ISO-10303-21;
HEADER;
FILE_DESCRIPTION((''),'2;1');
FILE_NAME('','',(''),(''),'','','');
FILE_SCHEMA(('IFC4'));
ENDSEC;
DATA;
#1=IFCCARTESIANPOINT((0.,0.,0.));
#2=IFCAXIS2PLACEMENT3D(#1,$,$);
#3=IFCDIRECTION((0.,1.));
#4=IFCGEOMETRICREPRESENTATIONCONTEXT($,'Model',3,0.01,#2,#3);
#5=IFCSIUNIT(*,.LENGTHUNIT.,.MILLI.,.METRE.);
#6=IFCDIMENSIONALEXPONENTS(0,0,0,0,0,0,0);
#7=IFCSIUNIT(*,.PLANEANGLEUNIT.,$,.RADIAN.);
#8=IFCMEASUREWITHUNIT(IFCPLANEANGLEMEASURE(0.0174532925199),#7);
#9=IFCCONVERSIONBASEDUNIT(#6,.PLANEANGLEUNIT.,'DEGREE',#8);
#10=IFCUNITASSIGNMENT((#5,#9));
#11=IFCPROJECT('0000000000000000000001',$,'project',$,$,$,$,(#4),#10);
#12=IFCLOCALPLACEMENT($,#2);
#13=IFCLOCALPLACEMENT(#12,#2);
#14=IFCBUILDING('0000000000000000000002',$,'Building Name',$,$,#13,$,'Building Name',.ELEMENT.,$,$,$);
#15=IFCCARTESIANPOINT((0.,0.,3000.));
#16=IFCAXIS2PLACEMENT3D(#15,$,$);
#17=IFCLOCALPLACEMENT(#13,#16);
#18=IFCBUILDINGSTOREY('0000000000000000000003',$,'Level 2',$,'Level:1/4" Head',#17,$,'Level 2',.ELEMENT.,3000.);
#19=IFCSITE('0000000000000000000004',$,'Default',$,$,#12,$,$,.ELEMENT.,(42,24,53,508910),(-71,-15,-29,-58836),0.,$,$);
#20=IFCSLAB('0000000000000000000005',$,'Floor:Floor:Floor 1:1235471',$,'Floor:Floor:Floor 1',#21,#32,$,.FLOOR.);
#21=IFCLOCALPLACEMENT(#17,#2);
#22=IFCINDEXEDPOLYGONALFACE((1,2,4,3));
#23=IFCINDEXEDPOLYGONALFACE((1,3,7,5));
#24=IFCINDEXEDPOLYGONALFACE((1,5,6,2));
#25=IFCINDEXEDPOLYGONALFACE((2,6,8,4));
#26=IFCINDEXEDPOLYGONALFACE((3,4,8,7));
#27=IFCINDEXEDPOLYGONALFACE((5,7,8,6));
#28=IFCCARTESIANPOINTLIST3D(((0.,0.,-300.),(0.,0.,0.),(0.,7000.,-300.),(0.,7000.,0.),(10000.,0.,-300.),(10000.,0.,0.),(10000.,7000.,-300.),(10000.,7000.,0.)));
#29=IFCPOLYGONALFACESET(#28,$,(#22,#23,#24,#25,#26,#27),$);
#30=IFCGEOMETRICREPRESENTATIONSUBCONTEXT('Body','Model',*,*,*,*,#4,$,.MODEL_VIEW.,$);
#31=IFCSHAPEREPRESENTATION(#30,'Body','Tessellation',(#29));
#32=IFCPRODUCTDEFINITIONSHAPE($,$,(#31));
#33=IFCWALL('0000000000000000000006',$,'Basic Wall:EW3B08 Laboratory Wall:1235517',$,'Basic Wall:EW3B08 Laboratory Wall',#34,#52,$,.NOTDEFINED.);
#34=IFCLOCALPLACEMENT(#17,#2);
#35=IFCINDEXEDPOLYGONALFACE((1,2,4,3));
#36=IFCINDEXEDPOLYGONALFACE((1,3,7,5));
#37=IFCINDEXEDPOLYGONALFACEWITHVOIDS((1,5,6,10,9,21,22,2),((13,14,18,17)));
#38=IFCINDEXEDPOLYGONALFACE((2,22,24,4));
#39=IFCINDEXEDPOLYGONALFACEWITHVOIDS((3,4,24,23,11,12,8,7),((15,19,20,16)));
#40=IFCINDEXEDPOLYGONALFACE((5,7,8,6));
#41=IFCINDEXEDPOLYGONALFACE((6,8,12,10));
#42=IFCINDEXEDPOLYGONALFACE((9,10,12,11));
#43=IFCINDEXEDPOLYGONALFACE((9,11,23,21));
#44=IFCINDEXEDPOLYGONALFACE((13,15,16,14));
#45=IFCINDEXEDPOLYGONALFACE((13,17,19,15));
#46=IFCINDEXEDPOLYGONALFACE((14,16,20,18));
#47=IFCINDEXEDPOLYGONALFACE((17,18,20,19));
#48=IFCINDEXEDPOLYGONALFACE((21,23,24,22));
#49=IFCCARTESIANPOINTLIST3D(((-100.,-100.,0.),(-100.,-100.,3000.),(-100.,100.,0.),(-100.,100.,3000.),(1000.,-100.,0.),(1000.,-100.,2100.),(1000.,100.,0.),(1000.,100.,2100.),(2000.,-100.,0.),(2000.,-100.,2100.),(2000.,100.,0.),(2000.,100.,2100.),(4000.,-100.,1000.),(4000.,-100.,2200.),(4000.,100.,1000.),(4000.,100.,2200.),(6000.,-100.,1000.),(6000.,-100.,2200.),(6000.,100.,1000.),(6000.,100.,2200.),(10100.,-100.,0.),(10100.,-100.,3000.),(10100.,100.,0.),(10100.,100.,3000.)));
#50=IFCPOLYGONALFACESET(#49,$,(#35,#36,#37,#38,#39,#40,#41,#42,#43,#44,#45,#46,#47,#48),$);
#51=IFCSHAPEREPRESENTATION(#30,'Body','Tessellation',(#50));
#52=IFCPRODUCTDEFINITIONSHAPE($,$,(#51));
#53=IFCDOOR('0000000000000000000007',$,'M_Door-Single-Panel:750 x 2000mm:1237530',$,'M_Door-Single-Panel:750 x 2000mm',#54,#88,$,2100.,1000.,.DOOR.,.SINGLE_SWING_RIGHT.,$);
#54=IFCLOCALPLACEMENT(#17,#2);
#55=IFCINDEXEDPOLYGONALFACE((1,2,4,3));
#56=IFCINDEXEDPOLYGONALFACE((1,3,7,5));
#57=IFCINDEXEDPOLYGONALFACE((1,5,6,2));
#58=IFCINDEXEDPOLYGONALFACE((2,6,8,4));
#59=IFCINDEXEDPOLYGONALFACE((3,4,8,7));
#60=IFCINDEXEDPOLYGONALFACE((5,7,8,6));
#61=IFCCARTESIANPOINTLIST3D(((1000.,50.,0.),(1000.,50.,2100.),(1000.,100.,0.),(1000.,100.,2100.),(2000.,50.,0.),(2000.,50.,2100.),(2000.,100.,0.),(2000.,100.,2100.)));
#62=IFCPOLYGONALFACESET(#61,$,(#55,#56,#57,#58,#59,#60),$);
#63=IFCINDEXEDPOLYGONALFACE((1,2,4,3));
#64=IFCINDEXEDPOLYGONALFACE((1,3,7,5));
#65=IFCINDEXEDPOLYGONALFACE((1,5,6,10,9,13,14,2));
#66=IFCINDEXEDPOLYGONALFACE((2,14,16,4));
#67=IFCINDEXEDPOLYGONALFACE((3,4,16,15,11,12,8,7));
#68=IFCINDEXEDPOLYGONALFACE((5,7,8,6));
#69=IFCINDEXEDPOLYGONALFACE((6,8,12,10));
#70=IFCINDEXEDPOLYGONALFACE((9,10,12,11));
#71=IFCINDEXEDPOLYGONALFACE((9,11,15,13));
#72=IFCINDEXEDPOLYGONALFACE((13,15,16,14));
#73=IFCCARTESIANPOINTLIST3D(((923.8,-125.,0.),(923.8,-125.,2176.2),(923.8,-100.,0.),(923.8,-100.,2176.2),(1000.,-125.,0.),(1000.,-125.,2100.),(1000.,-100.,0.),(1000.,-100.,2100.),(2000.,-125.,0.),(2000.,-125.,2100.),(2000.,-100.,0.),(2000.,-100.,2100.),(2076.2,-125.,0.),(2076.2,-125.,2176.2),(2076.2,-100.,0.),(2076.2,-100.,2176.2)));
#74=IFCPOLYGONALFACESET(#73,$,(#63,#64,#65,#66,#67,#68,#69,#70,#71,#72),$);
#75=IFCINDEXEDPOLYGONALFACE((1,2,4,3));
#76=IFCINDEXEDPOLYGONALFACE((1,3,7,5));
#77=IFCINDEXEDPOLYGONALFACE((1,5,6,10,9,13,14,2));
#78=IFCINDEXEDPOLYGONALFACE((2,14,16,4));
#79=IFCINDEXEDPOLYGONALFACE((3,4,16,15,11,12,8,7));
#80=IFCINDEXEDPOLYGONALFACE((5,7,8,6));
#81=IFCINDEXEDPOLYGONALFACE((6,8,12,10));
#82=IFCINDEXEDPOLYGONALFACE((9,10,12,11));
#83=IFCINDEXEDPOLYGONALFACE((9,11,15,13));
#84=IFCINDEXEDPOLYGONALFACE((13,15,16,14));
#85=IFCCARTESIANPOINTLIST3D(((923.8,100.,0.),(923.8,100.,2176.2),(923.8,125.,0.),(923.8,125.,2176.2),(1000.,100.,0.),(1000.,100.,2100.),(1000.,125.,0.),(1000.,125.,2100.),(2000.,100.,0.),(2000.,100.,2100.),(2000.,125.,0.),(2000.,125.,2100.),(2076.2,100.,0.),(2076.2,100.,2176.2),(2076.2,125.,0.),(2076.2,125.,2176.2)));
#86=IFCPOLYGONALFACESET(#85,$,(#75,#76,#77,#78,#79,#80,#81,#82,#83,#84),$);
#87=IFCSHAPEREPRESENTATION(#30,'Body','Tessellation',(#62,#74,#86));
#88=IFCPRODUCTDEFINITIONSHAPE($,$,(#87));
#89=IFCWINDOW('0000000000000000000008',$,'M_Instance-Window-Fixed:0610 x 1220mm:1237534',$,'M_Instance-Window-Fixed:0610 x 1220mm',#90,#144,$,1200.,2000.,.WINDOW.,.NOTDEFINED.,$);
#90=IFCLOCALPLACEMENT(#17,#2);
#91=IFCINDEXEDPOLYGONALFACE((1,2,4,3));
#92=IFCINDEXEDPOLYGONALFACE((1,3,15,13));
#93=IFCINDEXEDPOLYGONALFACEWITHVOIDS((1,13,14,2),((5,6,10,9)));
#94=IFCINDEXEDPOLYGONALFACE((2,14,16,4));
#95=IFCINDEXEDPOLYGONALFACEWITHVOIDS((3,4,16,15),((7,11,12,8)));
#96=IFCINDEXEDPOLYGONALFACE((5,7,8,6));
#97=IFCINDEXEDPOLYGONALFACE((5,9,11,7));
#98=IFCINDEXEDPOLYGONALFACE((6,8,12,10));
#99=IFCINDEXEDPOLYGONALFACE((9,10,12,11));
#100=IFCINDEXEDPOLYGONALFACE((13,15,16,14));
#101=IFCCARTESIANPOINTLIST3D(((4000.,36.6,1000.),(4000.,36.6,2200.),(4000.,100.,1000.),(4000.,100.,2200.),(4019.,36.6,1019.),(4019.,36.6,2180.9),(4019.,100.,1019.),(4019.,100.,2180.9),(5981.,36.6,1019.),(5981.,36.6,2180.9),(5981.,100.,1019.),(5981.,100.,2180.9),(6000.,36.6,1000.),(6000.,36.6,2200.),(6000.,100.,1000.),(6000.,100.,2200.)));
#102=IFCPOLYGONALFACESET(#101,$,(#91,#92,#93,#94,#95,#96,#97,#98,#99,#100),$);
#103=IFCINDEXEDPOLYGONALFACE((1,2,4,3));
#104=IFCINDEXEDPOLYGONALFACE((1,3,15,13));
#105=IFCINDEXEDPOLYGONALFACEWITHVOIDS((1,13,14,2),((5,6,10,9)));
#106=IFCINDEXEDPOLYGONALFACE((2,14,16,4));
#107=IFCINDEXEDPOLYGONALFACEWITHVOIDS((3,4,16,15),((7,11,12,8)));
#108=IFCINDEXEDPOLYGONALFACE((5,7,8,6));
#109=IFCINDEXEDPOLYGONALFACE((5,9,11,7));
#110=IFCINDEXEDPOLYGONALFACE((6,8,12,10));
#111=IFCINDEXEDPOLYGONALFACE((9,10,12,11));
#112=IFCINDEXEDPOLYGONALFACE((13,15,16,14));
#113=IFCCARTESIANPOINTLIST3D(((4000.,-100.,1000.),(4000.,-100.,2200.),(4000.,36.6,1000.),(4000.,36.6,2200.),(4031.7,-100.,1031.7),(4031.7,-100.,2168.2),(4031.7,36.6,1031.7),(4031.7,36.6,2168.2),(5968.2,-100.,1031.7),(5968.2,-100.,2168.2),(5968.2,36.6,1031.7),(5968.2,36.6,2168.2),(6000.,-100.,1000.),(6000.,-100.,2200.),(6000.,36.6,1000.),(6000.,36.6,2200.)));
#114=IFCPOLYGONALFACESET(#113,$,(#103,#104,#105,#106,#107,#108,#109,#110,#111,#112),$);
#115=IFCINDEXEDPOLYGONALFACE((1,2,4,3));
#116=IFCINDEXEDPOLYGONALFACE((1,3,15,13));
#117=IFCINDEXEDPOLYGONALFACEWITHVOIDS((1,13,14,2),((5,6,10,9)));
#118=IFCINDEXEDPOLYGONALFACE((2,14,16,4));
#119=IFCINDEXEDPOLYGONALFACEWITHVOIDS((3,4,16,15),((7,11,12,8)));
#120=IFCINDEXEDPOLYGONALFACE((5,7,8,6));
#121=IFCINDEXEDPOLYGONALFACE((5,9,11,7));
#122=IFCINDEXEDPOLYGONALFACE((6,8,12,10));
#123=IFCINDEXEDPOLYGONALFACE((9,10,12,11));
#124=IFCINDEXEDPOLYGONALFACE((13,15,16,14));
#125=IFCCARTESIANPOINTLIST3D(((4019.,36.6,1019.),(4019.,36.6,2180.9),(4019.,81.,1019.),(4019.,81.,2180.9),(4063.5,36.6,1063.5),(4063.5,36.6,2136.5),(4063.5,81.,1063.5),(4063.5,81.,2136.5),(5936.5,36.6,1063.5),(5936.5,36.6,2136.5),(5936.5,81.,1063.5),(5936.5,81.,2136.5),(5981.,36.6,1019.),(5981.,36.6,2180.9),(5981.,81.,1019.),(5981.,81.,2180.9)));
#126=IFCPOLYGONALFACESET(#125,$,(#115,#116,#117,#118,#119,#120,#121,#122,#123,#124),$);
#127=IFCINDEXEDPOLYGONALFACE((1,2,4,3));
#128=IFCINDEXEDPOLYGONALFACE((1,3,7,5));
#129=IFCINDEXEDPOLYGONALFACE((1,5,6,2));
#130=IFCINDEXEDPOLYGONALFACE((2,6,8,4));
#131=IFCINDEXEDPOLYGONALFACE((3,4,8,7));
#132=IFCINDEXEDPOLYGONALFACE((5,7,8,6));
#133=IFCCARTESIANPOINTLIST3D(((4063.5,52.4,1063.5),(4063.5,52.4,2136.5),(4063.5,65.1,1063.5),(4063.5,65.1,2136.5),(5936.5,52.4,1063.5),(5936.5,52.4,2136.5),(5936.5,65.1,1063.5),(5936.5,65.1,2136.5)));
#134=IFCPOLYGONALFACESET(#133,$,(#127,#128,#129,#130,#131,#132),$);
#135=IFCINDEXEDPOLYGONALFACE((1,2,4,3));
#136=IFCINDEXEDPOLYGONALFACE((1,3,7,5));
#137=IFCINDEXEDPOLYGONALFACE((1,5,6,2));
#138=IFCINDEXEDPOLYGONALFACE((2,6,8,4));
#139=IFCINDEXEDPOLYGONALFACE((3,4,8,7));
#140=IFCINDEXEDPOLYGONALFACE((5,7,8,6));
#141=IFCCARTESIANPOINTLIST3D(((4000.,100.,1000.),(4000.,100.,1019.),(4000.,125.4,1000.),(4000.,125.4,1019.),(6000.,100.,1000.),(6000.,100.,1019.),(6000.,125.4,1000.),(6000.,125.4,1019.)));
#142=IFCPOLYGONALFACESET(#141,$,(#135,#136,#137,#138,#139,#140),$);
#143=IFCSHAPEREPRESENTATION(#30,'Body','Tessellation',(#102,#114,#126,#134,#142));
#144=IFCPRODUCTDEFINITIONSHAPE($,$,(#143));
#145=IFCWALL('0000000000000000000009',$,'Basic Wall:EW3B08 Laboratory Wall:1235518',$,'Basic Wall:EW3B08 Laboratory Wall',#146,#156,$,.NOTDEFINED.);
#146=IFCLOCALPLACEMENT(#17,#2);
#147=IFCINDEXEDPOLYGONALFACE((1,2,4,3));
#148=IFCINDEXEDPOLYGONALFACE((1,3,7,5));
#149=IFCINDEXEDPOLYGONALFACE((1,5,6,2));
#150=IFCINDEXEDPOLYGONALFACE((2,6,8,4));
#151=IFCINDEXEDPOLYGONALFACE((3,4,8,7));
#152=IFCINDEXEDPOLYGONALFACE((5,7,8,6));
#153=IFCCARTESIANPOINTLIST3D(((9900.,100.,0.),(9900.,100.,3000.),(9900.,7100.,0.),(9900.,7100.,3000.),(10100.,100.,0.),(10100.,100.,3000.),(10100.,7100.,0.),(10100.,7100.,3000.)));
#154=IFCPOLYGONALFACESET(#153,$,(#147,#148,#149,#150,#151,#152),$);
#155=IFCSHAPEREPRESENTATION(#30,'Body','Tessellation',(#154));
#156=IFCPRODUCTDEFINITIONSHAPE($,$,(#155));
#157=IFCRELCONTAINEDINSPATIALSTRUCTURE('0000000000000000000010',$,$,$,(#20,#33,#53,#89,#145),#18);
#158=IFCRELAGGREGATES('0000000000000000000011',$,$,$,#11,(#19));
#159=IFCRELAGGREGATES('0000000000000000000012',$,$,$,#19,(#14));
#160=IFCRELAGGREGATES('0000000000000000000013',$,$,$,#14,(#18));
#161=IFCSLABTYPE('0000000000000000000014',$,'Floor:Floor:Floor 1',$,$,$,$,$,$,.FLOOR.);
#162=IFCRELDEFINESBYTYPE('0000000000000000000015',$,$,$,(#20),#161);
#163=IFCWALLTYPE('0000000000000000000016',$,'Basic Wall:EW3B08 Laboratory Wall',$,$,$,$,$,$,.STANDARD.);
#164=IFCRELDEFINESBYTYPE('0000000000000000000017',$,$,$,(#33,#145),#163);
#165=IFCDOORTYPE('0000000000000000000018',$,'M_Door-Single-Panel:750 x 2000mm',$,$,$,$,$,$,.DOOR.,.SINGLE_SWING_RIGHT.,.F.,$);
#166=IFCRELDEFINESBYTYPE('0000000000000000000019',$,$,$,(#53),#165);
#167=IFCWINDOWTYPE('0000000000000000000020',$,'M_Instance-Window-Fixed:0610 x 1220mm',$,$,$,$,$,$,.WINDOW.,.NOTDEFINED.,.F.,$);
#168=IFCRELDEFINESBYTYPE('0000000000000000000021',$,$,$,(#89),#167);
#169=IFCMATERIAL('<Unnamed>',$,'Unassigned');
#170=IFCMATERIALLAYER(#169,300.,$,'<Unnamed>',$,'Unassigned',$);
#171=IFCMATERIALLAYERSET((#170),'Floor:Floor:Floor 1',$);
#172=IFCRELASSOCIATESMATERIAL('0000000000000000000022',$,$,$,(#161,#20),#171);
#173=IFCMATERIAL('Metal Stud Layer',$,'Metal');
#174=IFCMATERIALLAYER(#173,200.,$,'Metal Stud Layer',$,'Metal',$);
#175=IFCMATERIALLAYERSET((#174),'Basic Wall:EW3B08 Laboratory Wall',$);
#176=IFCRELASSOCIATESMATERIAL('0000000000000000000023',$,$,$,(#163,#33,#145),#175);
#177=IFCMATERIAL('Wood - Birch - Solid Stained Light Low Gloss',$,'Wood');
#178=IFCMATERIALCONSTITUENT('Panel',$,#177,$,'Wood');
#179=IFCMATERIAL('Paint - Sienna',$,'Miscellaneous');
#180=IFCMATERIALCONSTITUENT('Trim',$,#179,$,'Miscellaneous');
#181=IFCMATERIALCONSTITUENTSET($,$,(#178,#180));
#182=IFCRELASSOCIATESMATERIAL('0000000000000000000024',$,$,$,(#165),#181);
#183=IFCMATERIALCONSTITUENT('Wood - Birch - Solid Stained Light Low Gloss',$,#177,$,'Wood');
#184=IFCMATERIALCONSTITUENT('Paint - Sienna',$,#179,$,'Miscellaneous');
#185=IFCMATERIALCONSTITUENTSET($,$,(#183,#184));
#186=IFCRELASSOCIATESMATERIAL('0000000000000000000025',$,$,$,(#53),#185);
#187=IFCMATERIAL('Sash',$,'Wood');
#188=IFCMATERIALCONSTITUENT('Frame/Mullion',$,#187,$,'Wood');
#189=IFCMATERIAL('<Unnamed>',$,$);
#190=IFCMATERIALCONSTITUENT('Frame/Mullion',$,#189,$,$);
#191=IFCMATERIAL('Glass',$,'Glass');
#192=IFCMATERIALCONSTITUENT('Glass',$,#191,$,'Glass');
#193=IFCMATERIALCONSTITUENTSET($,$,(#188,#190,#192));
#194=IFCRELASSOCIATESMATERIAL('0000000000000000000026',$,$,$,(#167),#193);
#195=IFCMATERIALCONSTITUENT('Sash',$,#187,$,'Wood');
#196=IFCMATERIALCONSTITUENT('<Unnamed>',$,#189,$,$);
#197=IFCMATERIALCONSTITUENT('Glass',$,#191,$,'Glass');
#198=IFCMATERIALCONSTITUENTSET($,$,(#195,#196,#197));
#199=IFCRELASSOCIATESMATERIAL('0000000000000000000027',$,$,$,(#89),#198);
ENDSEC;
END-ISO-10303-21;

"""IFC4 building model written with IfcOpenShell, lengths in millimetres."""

from ifc_helpers import new_model, entity, si_unit, converted_unit, direction, frame, frame_2d, origin, origin_2d_with_axis, place, context, subcontext, project, spatial, polyline, rectangle, outline, extrude, source, transform, mapped, material, layer, layer_set, layer_usage, constituent, constituent_set, type_object, type_shapes, element, fill, save


model = new_model("IFC4")

# Units and contexts
model_context = context("Model", 3, precision=0.01, world=origin(), true_north=direction((0.0, 1.0)))
body_context = subcontext(model_context, "Body", "Model", "MODEL_VIEW")
ifc_project = project(units=[si_unit("LENGTHUNIT", "METRE", prefix="MILLI"), converted_unit("PLANEANGLEUNIT", "DEGREE", entity("IfcPlaneAngleMeasure", 0.0174532925199), si_unit("PLANEANGLEUNIT", "RADIAN"), dimensions=[0, 0, 0, 0, 0, 0, 0])], contexts=[model_context])

# Site, building, storey
site_placement = place(None, origin())
site = spatial("IfcSite", under=ifc_project, at=site_placement, Name="Default", CompositionType="ELEMENT", RefLatitude=(42, 24, 53, 508910), RefLongitude=(-71, -15, -29, -58836), RefElevation=0.0)
building_placement = place(site_placement, origin())
building = spatial("IfcBuilding", under=site, at=building_placement, Name="Building Name", LongName="Building Name", CompositionType="ELEMENT")
storey_placement = place(building_placement, frame((0.0, 0.0, 3000.0)))
storey = spatial("IfcBuildingStorey", under=building, at=storey_placement, Name="Level 2", ObjectType="Level:1/4\" Head", LongName="Level 2", CompositionType="ELEMENT", Elevation=3000.0)

# Slab
ifc_material_1 = material(Name="<Unnamed>", Category="Unassigned")
ifc_layer_1 = layer(ifc_material_1, 300.0, Name="<Unnamed>", Category="Unassigned")
ifc_layer_set_1 = layer_set([ifc_layer_1], Name="Floor:Floor:Floor 1")
ifc_layer_usage_1 = layer_usage(ifc_layer_set_1, "AXIS3", "POSITIVE", 0.0)
slab_type = type_object("IfcSlabType", Name="Floor:Floor:Floor 1", PredefinedType="FLOOR", material=ifc_layer_set_1)
slab_placement = place(storey_placement, origin())
element("IfcSlab", 1, at=slab_placement, inside=storey, type_object=slab_type, material=ifc_layer_usage_1, Name="Floor:Floor:Floor 1:1235471", ObjectType="Floor:Floor:Floor 1", PredefinedType="FLOOR", context=body_context, shape_type="SweptSolid", body=[
    extrude(rectangle(XDim=7000.0, YDim=10000.0, at=origin_2d_with_axis()), frame((5000.0, 3500.0, 0.0), z_axis=(0.0, 0.0, -1.0), x_axis=(0.0, 1.0, 0.0)), (0.0, 0.0, 1.0), 300.0),
])

# Wall, openings, door, window
ifc_material_2 = material(Name="Metal Stud Layer", Category="Metal")
ifc_layer_2 = layer(ifc_material_2, 200.0, Name="Metal Stud Layer", Category="Metal")
ifc_layer_set_2 = layer_set([ifc_layer_2], Name="Basic Wall:EW3B08 Laboratory Wall")
ifc_layer_usage_2 = layer_usage(ifc_layer_set_2, "AXIS2", "NEGATIVE", 100.0)
wall_type = type_object("IfcWallType", Name="Basic Wall:EW3B08 Laboratory Wall", PredefinedType="STANDARD", material=ifc_layer_set_2)
wall_1_placement = place(storey_placement, frame((-100.0, 0.0, 0.0)))
wall_1 = element("IfcWall", 2, at=wall_1_placement, inside=storey, type_object=wall_type, material=ifc_layer_usage_2, Name="Basic Wall:EW3B08 Laboratory Wall:1235517", ObjectType="Basic Wall:EW3B08 Laboratory Wall", PredefinedType="NOTDEFINED", context=body_context, shape_type="SweptSolid", body=[
    extrude(rectangle(XDim=10200.0, YDim=200.0, at=frame_2d((5100.0, 0.0), x_axis=(1.0, 0.0))), origin(), (0.0, 0.0, 1.0), 3000.0),
])
opening_1_placement = place(wall_1_placement, frame((1100.0, -100.0, 0.0)))
opening_1 = element("IfcOpeningElement", 3, at=opening_1_placement, cuts=wall_1, PredefinedType="OPENING", context=body_context, shape_type="SweptSolid", body=[
    extrude(rectangle(XDim=1000.0, YDim=2100.0, at=frame_2d((1050.0, 500.0), x_axis=(0.0, 1.0))), frame((0.0, 0.0, 0.0), z_axis=(0.0, 1.0, 0.0), x_axis=(0.0, 0.0, 1.0)), (0.0, 0.0, 1.0), 200.0),
])
opening_2_placement = place(wall_1_placement, frame((4100.0, -100.0, 1000.0)))
opening_2 = element("IfcOpeningElement", 4, at=opening_2_placement, cuts=wall_1, PredefinedType="OPENING", context=body_context, shape_type="SweptSolid", body=[
    extrude(rectangle(XDim=1200.0, YDim=2000.0, at=frame_2d((600.0, 1000.0), x_axis=(-1.0, 0.0))), frame((0.0, 0.0, 0.0), z_axis=(0.0, 1.0, 0.0), x_axis=(0.0, 0.0, 1.0)), (0.0, 0.0, 1.0), 200.0),
])
ifc_material_3 = material(Name="Wood - Birch - Solid Stained Light Low Gloss", Category="Wood")
ifc_constituent_1 = constituent(ifc_material_3, Name="Wood - Birch - Solid Stained Light Low Gloss", Category="Wood")
ifc_material_4 = material(Name="Paint - Sienna", Category="Miscellaneous")
ifc_constituent_2 = constituent(ifc_material_4, Name="Paint - Sienna", Category="Miscellaneous")
ifc_constituent_set_1 = constituent_set(constituents=[ifc_constituent_1, ifc_constituent_2])
ifc_constituent_3 = constituent(ifc_material_3, Name="Panel", Category="Wood")
ifc_constituent_4 = constituent(ifc_material_4, Name="Trim", Category="Miscellaneous")
ifc_constituent_set_2 = constituent_set(constituents=[ifc_constituent_3, ifc_constituent_4])
door_type = type_object("IfcDoorType", Name="M_Door-Single-Panel:750 x 2000mm", OperationType="SINGLE_SWING_RIGHT", ParameterTakesPrecedence=False, PredefinedType="DOOR", material=ifc_constituent_set_2)
shared_shape_1 = source(origin(), body_context, "Body", "SweptSolid", [
    extrude(rectangle(XDim=50.0, YDim=1000.0, at=frame_2d((0.0, 0.0), x_axis=(1.0, 0.0))), frame((500.0, 175.0, 0.0), z_axis=(0.0, 0.0, 1.0), x_axis=(0.0, 1.0, 0.0)), (0.0, 0.0, 1.0), 2100.0),
    extrude(outline(polyline([(-1107.2, -576.2), (1069.0, -576.2), (1069.0, -500.0), (-1031.0, -500.0), (-1031.0, 500.0), (1069.0, 500.0), (1069.0, 576.2), (-1107.2, 576.2), (-1107.2, -576.2)])), frame((500.0, -25.0, 1069.0), z_axis=(0.0, 1.0, 0.0), x_axis=(0.0, 0.0, -1.0)), (0.0, 0.0, 1.0), 25.0),
    extrude(outline(polyline([(-576.2, -1107.2), (576.2, -1107.2), (576.2, 1069.0), (500.0, 1069.0), (500.0, -1031.0), (-500.0, -1031.0), (-500.0, 1069.0), (-576.2, 1069.0), (-576.2, -1107.2)])), frame((500.0, 200.0, 1069.0), z_axis=(0.0, 1.0, 0.0), x_axis=(1.0, 0.0, 0.0)), (0.0, 0.0, 1.0), 25.0),
])
type_shapes(door_type, [shared_shape_1])
door_1_placement = place(opening_1_placement, origin())
door_1 = element("IfcDoor", 5, at=door_1_placement, inside=storey, type_object=door_type, material=ifc_constituent_set_1, Name="M_Door-Single-Panel:750 x 2000mm:1237530", ObjectType="M_Door-Single-Panel:750 x 2000mm", OperationType="SINGLE_SWING_RIGHT", OverallHeight=2100.0, OverallWidth=1000.0, PredefinedType="DOOR", context=body_context, shape_type="MappedRepresentation", body=[
    mapped(shared_shape_1, transform((0.0, 0.0, 0.0), scale=1.0)),
])
fill(opening_1, door_1)
ifc_material_5 = material(Name="Sash", Category="Wood")
ifc_constituent_5 = constituent(ifc_material_5, Name="Sash", Category="Wood")
ifc_material_6 = material(Name="<Unnamed>")
ifc_constituent_6 = constituent(ifc_material_6, Name="<Unnamed>")
ifc_material_7 = material(Name="Glass", Category="Glass")
ifc_constituent_7 = constituent(ifc_material_7, Name="Glass", Category="Glass")
ifc_constituent_set_3 = constituent_set(constituents=[ifc_constituent_5, ifc_constituent_6, ifc_constituent_7])
ifc_constituent_8 = constituent(ifc_material_5, Name="Frame/Mullion", Category="Wood")
ifc_constituent_9 = constituent(ifc_material_6, Name="Frame/Mullion")
ifc_constituent_10 = constituent(ifc_material_7, Name="Glass", Category="Glass")
ifc_constituent_set_4 = constituent_set(constituents=[ifc_constituent_8, ifc_constituent_9, ifc_constituent_10])
window_type = type_object("IfcWindowType", Name="M_Instance-Window-Fixed:0610 x 1220mm", ParameterTakesPrecedence=False, PartitioningType="NOTDEFINED", PredefinedType="WINDOW", material=ifc_constituent_set_4)
shared_shape_2 = source(origin(), body_context, "Body", "SweptSolid", [
    extrude(outline(polyline([(-600.0, -1000.0), (600.0, -1000.0), (600.0, 1000.0), (-600.0, 1000.0), (-600.0, -1000.0)]), holes=[polyline([(-581.0, -981.0), (-581.0, 981.0), (581.0, 981.0), (581.0, -981.0), (-581.0, -981.0)])]), frame((1000.0, 136.6, 600.0), z_axis=(0.0, 1.0, 0.0), x_axis=(0.0, 0.0, -1.0)), (0.0, 0.0, 1.0), 63.5),
    extrude(outline(polyline([(-1000.0, -600.0), (1000.0, -600.0), (1000.0, 600.0), (-1000.0, 600.0), (-1000.0, -600.0)]), holes=[polyline([(-968.2, -568.2), (-968.2, 568.2), (968.2, 568.2), (968.2, -568.2), (-968.2, -568.2)])]), frame((1000.0, 0.0, 600.0), z_axis=(0.0, 1.0, 0.0), x_axis=(1.0, 0.0, 0.0)), (0.0, 0.0, 1.0), 136.6),
    extrude(outline(polyline([(-981.0, -581.0), (981.0, -581.0), (981.0, 581.0), (-981.0, 581.0), (-981.0, -581.0)]), holes=[polyline([(-936.5, -536.5), (-936.5, 536.5), (936.5, 536.5), (936.5, -536.5), (-936.5, -536.5)])]), frame((1000.0, 136.6, 600.0), z_axis=(0.0, 1.0, 0.0), x_axis=(1.0, 0.0, 0.0)), (0.0, 0.0, 1.0), 44.5),
    extrude(rectangle(XDim=12.7, YDim=1873.0, at=frame_2d((0.0, 0.0), x_axis=(1.0, 0.0))), frame((1000.0, 158.8, 63.5), z_axis=(0.0, 0.0, 1.0), x_axis=(0.0, 1.0, 0.0)), (0.0, 0.0, 1.0), 1073.0),
    extrude(rectangle(XDim=25.4, YDim=2000.0, at=frame_2d((0.0, 0.0), x_axis=(1.0, 0.0))), frame((1000.0, 212.7, 0.0), z_axis=(0.0, 0.0, 1.0), x_axis=(0.0, -1.0, 0.0)), (0.0, 0.0, 1.0), 19.1),
])
type_shapes(window_type, [shared_shape_2])
window_1_placement = place(opening_2_placement, origin())
window_1 = element("IfcWindow", 6, at=window_1_placement, inside=storey, type_object=window_type, material=ifc_constituent_set_3, Name="M_Instance-Window-Fixed:0610 x 1220mm:1237534", ObjectType="M_Instance-Window-Fixed:0610 x 1220mm", OverallHeight=1200.0, OverallWidth=2000.0, PartitioningType="NOTDEFINED", PredefinedType="WINDOW", context=body_context, shape_type="MappedRepresentation", body=[
    mapped(shared_shape_2, transform((0.0, 0.0, 0.0), scale=1.0)),
])
fill(opening_2, window_1)

# Wall
ifc_layer_usage_3 = layer_usage(ifc_layer_set_2, "AXIS2", "NEGATIVE", 100.0)
wall_2_placement = place(storey_placement, frame((10000.0, 100.0, 0.0), z_axis=(0.0, 0.0, 1.0), x_axis=(0.0, 1.0, 0.0)))
element("IfcWall", 7, at=wall_2_placement, inside=storey, type_object=wall_type, material=ifc_layer_usage_3, Name="Basic Wall:EW3B08 Laboratory Wall:1235518", ObjectType="Basic Wall:EW3B08 Laboratory Wall", PredefinedType="NOTDEFINED", context=body_context, shape_type="SweptSolid", body=[
    extrude(rectangle(XDim=7000.0, YDim=200.0, at=frame_2d((3500.0, 0.0), x_axis=(-1.0, 0.0))), origin(), (0.0, 0.0, 1.0), 3000.0),
])

save(model, "model.ifc")
